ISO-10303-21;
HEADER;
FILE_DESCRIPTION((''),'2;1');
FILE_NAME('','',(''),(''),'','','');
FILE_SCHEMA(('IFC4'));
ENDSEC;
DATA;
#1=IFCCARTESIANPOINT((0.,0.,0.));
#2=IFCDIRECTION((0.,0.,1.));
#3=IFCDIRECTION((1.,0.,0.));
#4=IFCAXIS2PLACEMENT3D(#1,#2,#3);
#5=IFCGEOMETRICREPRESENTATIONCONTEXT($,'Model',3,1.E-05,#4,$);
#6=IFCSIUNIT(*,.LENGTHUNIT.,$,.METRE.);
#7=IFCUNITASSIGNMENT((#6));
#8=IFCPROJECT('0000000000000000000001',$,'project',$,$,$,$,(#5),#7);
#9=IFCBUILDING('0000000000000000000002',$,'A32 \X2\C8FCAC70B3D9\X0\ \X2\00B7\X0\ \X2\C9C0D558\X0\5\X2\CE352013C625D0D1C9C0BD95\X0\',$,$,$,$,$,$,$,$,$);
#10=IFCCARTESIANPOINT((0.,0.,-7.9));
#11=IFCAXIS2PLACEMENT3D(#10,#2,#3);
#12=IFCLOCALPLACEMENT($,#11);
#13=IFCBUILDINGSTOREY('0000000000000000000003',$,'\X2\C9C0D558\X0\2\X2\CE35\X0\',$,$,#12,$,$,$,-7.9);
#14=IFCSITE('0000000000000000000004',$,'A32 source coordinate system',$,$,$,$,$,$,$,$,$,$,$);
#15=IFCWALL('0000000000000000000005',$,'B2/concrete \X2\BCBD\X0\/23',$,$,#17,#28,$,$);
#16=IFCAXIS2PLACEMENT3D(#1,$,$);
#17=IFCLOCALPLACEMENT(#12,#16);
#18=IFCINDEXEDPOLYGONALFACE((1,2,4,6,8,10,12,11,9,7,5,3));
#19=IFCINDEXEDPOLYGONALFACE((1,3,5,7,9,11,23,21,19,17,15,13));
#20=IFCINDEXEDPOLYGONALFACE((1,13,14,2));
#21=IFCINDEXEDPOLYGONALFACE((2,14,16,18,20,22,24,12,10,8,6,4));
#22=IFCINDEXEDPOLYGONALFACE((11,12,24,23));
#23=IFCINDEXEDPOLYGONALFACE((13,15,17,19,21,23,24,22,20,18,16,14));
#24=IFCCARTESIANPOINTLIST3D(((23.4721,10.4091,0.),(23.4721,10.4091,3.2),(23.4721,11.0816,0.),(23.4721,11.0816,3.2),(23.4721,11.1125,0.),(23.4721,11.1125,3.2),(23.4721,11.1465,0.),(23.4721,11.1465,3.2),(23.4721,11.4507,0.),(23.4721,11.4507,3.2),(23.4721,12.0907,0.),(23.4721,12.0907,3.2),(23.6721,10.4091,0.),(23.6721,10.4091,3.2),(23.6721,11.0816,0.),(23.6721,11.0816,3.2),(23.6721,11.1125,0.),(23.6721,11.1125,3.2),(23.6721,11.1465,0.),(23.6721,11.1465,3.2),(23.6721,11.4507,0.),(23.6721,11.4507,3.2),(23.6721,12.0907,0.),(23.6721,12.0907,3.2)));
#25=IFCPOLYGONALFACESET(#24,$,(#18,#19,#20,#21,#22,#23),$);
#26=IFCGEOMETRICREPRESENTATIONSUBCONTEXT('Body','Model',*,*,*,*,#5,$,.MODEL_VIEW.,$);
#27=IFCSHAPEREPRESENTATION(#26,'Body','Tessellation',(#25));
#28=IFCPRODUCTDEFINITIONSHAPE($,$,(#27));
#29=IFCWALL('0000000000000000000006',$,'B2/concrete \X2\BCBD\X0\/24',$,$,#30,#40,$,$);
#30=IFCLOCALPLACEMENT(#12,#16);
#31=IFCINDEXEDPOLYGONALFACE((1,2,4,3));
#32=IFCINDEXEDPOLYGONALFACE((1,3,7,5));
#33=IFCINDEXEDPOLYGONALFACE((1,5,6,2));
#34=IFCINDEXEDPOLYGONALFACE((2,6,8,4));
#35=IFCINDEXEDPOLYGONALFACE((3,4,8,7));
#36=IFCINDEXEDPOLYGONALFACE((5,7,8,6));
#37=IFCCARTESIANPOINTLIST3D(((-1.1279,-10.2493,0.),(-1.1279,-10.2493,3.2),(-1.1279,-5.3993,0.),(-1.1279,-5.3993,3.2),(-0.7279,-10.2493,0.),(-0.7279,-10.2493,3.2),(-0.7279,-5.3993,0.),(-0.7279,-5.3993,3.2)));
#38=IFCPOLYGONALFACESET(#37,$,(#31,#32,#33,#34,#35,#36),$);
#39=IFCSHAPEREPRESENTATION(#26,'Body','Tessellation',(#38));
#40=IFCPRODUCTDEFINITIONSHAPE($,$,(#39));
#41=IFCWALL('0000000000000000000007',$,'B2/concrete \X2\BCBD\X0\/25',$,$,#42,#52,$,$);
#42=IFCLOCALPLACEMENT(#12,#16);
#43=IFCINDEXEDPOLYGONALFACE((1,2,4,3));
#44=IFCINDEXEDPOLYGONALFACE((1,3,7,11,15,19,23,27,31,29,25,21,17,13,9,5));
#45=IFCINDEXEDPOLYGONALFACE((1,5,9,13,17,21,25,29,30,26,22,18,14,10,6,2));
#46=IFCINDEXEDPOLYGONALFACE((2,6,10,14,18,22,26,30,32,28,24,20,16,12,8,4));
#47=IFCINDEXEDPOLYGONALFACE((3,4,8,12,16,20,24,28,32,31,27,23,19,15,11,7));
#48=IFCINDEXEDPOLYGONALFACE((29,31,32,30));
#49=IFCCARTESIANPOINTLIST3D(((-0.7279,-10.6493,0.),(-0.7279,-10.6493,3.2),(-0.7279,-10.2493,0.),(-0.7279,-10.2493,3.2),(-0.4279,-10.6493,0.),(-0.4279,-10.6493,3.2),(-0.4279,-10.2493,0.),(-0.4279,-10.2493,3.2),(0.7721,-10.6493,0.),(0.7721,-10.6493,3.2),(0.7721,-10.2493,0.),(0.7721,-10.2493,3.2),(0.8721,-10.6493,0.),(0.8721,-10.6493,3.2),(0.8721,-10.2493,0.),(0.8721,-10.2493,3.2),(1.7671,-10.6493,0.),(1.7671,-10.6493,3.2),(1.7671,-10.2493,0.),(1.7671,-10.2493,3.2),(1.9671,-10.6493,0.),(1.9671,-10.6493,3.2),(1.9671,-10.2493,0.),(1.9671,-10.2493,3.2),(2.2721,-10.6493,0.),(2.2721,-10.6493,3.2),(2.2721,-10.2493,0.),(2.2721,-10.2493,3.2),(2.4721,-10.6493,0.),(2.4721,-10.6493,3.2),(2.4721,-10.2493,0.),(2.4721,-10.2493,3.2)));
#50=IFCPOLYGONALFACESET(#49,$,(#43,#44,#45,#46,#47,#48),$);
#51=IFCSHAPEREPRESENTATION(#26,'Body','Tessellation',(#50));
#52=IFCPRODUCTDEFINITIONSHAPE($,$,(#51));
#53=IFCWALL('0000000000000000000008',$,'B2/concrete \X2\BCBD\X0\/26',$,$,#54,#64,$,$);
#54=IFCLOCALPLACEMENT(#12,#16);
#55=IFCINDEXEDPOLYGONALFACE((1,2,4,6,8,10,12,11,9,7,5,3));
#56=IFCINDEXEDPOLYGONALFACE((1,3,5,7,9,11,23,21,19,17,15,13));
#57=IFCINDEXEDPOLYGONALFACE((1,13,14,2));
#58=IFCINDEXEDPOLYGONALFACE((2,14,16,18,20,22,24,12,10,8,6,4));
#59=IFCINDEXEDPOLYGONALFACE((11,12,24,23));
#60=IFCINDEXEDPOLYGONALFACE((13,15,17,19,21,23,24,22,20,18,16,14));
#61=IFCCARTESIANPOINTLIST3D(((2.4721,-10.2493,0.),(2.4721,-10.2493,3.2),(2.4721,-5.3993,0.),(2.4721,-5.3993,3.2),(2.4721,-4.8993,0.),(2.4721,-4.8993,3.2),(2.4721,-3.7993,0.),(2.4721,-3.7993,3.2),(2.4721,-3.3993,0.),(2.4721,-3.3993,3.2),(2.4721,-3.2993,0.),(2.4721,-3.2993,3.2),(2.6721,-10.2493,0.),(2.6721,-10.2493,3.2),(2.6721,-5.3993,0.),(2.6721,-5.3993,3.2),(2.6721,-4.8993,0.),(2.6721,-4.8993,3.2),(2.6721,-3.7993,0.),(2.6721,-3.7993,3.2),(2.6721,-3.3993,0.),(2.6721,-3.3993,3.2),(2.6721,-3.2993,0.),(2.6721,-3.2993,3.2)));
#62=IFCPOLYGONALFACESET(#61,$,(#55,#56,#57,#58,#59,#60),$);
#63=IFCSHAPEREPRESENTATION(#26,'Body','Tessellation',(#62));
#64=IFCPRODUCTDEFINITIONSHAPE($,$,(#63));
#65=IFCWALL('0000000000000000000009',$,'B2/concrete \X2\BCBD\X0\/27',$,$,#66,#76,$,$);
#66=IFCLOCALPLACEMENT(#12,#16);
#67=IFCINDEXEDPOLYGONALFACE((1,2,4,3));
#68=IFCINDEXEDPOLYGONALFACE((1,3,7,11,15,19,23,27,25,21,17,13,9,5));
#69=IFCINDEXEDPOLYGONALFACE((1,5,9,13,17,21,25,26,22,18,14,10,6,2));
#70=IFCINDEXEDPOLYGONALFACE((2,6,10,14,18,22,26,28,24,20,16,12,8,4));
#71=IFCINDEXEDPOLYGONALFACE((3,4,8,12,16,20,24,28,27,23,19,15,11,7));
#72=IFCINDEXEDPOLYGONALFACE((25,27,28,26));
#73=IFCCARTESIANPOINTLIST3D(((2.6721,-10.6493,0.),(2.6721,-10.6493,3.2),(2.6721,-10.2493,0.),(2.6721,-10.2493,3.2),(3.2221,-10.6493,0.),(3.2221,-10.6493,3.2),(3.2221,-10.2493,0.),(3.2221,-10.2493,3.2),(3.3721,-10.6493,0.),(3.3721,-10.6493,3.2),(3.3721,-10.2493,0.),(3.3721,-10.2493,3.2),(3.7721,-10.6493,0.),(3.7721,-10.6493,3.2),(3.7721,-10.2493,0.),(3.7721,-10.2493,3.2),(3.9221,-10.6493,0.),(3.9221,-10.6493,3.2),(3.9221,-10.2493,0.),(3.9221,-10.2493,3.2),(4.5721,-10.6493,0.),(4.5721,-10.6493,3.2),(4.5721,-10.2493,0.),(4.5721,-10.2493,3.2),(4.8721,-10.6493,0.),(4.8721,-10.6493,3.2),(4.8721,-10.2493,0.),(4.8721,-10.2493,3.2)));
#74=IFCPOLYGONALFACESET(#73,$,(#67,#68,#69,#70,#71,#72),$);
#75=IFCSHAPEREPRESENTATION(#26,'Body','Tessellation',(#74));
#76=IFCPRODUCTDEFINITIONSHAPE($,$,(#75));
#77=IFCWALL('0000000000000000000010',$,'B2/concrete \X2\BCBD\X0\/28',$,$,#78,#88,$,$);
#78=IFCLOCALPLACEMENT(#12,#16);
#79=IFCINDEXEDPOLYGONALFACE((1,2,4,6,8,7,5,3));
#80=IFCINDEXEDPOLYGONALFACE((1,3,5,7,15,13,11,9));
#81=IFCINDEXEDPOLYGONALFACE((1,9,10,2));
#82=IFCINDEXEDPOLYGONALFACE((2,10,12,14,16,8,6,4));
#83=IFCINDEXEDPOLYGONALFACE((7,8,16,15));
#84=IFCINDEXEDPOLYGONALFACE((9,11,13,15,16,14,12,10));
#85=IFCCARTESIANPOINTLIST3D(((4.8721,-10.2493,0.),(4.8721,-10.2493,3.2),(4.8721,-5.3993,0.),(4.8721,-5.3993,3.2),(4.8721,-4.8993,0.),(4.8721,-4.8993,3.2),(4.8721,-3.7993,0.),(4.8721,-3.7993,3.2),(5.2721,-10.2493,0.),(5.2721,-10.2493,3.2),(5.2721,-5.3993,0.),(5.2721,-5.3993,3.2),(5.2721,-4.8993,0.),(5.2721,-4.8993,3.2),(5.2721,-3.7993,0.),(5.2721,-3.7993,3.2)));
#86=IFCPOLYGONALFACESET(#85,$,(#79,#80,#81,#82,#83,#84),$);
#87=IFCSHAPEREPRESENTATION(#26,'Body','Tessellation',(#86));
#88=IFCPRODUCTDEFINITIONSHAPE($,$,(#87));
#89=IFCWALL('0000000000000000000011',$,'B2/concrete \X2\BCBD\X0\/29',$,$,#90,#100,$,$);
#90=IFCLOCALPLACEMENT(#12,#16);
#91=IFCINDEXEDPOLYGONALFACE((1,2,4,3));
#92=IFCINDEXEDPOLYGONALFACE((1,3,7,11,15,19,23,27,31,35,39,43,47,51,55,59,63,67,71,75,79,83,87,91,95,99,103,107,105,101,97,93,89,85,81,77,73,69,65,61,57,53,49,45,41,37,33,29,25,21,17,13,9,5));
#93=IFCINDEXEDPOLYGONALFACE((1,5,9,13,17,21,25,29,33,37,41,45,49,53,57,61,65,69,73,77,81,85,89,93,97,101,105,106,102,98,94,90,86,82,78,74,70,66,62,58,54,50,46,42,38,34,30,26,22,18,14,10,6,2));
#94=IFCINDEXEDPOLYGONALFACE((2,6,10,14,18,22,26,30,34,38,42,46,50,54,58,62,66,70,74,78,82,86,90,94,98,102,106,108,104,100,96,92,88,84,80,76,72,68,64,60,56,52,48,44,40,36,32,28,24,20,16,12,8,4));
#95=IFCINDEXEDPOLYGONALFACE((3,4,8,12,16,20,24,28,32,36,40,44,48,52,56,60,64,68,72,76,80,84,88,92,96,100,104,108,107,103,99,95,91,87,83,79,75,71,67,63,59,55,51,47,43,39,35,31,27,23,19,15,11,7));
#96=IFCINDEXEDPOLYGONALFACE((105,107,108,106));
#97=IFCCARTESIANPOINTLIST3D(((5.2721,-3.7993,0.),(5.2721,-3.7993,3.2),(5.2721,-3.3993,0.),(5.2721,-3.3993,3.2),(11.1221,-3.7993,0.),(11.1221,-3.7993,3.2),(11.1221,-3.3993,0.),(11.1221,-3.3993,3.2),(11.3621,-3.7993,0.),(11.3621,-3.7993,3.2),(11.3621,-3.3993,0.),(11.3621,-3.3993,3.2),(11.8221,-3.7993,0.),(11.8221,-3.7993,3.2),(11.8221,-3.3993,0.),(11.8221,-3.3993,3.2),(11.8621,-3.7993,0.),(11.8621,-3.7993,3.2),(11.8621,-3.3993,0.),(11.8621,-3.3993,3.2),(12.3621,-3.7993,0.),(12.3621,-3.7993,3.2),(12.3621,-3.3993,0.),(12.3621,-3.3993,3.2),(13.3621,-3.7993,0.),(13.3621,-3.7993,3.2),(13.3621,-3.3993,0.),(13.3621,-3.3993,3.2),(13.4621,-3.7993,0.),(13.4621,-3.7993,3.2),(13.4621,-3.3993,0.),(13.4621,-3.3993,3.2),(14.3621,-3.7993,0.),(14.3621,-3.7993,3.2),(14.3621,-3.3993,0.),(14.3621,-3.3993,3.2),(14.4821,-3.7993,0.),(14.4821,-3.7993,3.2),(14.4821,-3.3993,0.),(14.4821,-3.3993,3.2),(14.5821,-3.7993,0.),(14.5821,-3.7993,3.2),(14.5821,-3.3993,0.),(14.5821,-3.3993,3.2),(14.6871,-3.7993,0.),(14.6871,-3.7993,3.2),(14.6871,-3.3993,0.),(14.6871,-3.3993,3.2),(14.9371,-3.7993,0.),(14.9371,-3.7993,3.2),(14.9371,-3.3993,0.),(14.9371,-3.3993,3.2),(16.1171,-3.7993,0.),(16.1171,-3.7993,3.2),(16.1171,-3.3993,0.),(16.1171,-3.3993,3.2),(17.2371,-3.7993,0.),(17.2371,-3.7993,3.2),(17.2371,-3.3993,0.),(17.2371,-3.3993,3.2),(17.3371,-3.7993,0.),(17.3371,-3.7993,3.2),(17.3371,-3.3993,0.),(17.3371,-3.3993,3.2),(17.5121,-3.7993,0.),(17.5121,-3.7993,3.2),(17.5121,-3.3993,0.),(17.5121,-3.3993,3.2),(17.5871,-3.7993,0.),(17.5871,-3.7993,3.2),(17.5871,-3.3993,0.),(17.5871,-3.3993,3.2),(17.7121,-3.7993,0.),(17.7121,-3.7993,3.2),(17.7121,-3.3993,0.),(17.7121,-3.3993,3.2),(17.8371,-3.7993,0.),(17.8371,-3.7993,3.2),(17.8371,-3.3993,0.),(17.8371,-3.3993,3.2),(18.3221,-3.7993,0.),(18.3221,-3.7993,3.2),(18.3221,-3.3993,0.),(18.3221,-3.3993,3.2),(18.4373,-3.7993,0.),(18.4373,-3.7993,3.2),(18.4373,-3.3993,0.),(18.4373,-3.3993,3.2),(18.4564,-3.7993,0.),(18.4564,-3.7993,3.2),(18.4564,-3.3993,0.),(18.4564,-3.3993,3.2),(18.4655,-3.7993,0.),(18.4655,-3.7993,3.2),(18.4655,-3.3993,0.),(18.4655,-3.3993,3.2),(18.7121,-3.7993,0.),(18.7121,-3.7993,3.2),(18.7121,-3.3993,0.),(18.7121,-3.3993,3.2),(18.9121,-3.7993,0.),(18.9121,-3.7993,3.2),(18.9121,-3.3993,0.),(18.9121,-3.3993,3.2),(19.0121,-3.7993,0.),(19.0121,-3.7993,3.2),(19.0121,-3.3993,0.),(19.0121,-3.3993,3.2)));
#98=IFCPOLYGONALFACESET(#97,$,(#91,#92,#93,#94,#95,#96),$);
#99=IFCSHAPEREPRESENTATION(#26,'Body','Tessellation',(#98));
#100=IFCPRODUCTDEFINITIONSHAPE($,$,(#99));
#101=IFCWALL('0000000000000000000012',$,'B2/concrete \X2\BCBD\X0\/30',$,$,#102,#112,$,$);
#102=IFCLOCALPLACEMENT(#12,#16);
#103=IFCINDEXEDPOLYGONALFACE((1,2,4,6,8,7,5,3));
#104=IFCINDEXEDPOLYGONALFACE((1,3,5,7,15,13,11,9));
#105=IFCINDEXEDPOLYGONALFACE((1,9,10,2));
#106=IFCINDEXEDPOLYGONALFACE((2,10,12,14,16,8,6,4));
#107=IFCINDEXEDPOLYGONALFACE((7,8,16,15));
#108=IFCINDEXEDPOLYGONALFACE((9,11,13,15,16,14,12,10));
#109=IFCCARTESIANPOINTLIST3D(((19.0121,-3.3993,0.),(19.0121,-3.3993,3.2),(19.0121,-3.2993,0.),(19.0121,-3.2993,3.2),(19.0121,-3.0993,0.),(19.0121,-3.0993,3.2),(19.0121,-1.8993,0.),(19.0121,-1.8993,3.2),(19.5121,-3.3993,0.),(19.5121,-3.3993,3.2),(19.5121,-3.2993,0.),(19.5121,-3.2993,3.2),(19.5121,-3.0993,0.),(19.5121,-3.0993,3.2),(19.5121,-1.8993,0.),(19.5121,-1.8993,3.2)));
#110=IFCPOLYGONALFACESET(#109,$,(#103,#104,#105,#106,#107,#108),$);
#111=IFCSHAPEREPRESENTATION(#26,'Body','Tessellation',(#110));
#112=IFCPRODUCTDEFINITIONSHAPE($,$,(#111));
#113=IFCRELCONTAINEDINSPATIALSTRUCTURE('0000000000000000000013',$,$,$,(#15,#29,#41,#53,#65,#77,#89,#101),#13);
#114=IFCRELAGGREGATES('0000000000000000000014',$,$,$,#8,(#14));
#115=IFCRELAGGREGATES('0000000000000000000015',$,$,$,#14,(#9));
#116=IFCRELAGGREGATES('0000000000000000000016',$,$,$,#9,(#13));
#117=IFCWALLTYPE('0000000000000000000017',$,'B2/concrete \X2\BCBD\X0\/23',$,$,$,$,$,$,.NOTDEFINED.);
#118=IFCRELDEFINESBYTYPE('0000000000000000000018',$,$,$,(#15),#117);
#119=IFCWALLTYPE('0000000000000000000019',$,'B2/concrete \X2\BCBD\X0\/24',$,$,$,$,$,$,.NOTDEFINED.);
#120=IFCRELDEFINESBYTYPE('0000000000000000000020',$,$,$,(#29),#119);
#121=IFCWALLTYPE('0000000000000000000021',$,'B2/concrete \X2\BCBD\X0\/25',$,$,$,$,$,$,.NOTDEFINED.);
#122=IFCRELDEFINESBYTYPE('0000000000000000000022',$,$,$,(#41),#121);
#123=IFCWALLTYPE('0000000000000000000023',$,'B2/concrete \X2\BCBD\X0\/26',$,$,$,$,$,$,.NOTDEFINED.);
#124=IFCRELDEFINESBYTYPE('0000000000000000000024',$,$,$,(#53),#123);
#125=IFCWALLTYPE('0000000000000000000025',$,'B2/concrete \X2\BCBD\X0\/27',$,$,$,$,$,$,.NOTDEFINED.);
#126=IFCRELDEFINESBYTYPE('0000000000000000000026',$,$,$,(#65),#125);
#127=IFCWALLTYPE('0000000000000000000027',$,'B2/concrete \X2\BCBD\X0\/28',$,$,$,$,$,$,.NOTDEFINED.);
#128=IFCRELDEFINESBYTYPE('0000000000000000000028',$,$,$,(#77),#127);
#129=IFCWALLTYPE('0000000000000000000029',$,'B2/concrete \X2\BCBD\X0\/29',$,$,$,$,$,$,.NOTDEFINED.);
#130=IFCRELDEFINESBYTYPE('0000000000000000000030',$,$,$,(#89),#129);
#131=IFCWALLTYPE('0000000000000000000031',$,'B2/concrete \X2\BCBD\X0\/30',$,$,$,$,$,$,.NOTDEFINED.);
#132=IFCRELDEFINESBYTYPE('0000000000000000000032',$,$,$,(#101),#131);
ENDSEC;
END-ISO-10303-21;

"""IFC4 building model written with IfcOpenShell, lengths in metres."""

from ifc_helpers import new_model, si_unit, frame, origin, origin_with_axes, place, context, subcontext, project, spatial, polyline, outline, extrude, source, transform, mapped, type_object, type_shapes, element, save


model = new_model("IFC4")

# Units and contexts
model_context = context("Model", 3, precision=1e-05, world=origin_with_axes())
body_context = subcontext(model_context, "Body", "Model", "MODEL_VIEW")
ifc_project = project(units=[si_unit("LENGTHUNIT", "METRE")], contexts=[model_context])

# Site, building, storey
site = spatial("IfcSite", under=ifc_project, Name="A32 source coordinate system")
building = spatial("IfcBuilding", under=site, Name="A32 주거동 · 지하5층–옥탑지붕")
storey_placement = place(None, frame((0.0, 0.0, -7.9), z_axis=(0.0, 0.0, 1.0), x_axis=(1.0, 0.0, 0.0)))
storey = spatial("IfcBuildingStorey", under=building, at=storey_placement, Name="지하2층", Elevation=-7.9)

# Walls
wall_type_1 = type_object("IfcWallType", Name="B2/concrete 벽/23", PredefinedType="NOTDEFINED")
shared_shape_1 = source(origin(), body_context, "Body", "SweptSolid", [
    extrude(outline(polyline([(23.4721, 11.1125), (23.4721, 11.1465), (23.4721, 11.4507), (23.4721, 12.0907), (23.6721, 12.0907), (23.6721, 11.4507), (23.6721, 11.1465), (23.6721, 11.1125), (23.6721, 11.0816), (23.6721, 10.4091), (23.4721, 10.4091), (23.4721, 11.0816), (23.4721, 11.1125)])), origin(), (0.0, 0.0, 1.0), 3.2),
])
type_shapes(wall_type_1, [shared_shape_1])
wall_1_placement = place(storey_placement, origin_with_axes())
element("IfcWall", 1, at=wall_1_placement, inside=storey, type_object=wall_type_1, Name="B2/concrete 벽/23", context=body_context, shape_type="MappedRepresentation", body=[
    mapped(shared_shape_1, transform((0.0, 0.0, 0.0), scale=1.0)),
])
wall_type_2 = type_object("IfcWallType", Name="B2/concrete 벽/24", PredefinedType="NOTDEFINED")
shared_shape_2 = source(origin(), body_context, "Body", "SweptSolid", [
    extrude(outline(polyline([(-1.1279, -10.2493), (-1.1279, -5.3993), (-0.7279, -5.3993), (-0.7279, -10.2493), (-1.1279, -10.2493)])), origin(), (0.0, 0.0, 1.0), 3.2),
])
type_shapes(wall_type_2, [shared_shape_2])
wall_2_placement = place(storey_placement, origin_with_axes())
element("IfcWall", 2, at=wall_2_placement, inside=storey, type_object=wall_type_2, Name="B2/concrete 벽/24", context=body_context, shape_type="MappedRepresentation", body=[
    mapped(shared_shape_2, transform((0.0, 0.0, 0.0), scale=1.0)),
])
wall_type_3 = type_object("IfcWallType", Name="B2/concrete 벽/25", PredefinedType="NOTDEFINED")
shared_shape_3 = source(origin(), body_context, "Body", "SweptSolid", [
    extrude(outline(polyline([(0.8721, -10.2493), (1.7671, -10.2493), (1.9671, -10.2493), (2.2721, -10.2493), (2.4721, -10.2493), (2.4721, -10.6493), (2.2721, -10.6493), (1.9671, -10.6493), (1.7671, -10.6493), (0.8721, -10.6493), (0.7721, -10.6493), (-0.4279, -10.6493), (-0.7279, -10.6493), (-0.7279, -10.2493), (-0.4279, -10.2493), (0.7721, -10.2493), (0.8721, -10.2493)])), origin(), (0.0, 0.0, 1.0), 3.2),
])
type_shapes(wall_type_3, [shared_shape_3])
wall_3_placement = place(storey_placement, origin_with_axes())
element("IfcWall", 3, at=wall_3_placement, inside=storey, type_object=wall_type_3, Name="B2/concrete 벽/25", context=body_context, shape_type="MappedRepresentation", body=[
    mapped(shared_shape_3, transform((0.0, 0.0, 0.0), scale=1.0)),
])
wall_type_4 = type_object("IfcWallType", Name="B2/concrete 벽/26", PredefinedType="NOTDEFINED")
shared_shape_4 = source(origin(), body_context, "Body", "SweptSolid", [
    extrude(outline(polyline([(2.4721, -3.7993), (2.4721, -3.3993), (2.4721, -3.2993), (2.6721, -3.2993), (2.6721, -3.3993), (2.6721, -3.7993), (2.6721, -4.8993), (2.6721, -5.3993), (2.6721, -10.2493), (2.4721, -10.2493), (2.4721, -5.3993), (2.4721, -4.8993), (2.4721, -3.7993)])), origin(), (0.0, 0.0, 1.0), 3.2),
])
type_shapes(wall_type_4, [shared_shape_4])
wall_4_placement = place(storey_placement, origin_with_axes())
element("IfcWall", 4, at=wall_4_placement, inside=storey, type_object=wall_type_4, Name="B2/concrete 벽/26", context=body_context, shape_type="MappedRepresentation", body=[
    mapped(shared_shape_4, transform((0.0, 0.0, 0.0), scale=1.0)),
])
wall_type_5 = type_object("IfcWallType", Name="B2/concrete 벽/27", PredefinedType="NOTDEFINED")
shared_shape_5 = source(origin(), body_context, "Body", "SweptSolid", [
    extrude(outline(polyline([(3.7721, -10.2493), (3.9221, -10.2493), (4.5721, -10.2493), (4.8721, -10.2493), (4.8721, -10.6493), (4.5721, -10.6493), (3.9221, -10.6493), (3.7721, -10.6493), (3.3721, -10.6493), (3.2221, -10.6493), (2.6721, -10.6493), (2.6721, -10.2493), (3.2221, -10.2493), (3.3721, -10.2493), (3.7721, -10.2493)])), origin(), (0.0, 0.0, 1.0), 3.2),
])
type_shapes(wall_type_5, [shared_shape_5])
wall_5_placement = place(storey_placement, origin_with_axes())
element("IfcWall", 5, at=wall_5_placement, inside=storey, type_object=wall_type_5, Name="B2/concrete 벽/27", context=body_context, shape_type="MappedRepresentation", body=[
    mapped(shared_shape_5, transform((0.0, 0.0, 0.0), scale=1.0)),
])
wall_type_6 = type_object("IfcWallType", Name="B2/concrete 벽/28", PredefinedType="NOTDEFINED")
shared_shape_6 = source(origin(), body_context, "Body", "SweptSolid", [
    extrude(outline(polyline([(4.8721, -3.7993), (5.2721, -3.7993), (5.2721, -4.8993), (5.2721, -5.3993), (5.2721, -10.2493), (4.8721, -10.2493), (4.8721, -5.3993), (4.8721, -4.8993), (4.8721, -3.7993)])), origin(), (0.0, 0.0, 1.0), 3.2),
])
type_shapes(wall_type_6, [shared_shape_6])
wall_6_placement = place(storey_placement, origin_with_axes())
element("IfcWall", 6, at=wall_6_placement, inside=storey, type_object=wall_type_6, Name="B2/concrete 벽/28", context=body_context, shape_type="MappedRepresentation", body=[
    mapped(shared_shape_6, transform((0.0, 0.0, 0.0), scale=1.0)),
])
wall_type_7 = type_object("IfcWallType", Name="B2/concrete 벽/29", PredefinedType="NOTDEFINED")
shared_shape_7 = source(origin(), body_context, "Body", "SweptSolid", [
    extrude(outline(polyline([(11.3621, -3.3993), (11.8221, -3.3993), (11.8621, -3.3993), (12.3621, -3.3993), (13.3621, -3.3993), (13.4621, -3.3993), (14.3621, -3.3993), (14.4821, -3.3993), (14.5821, -3.3993), (14.6871, -3.3993), (14.9371, -3.3993), (16.1171, -3.3993), (17.2371, -3.3993), (17.3371, -3.3993), (17.5121, -3.3993), (17.5871, -3.3993), (17.7121, -3.3993), (17.8371, -3.3993), (18.3221, -3.3993), (18.4373, -3.3993), (18.4564, -3.3993), (18.4655, -3.3993), (18.7121, -3.3993), (18.9121, -3.3993), (19.0121, -3.3993), (19.0121, -3.7993), (18.9121, -3.7993), (18.7121, -3.7993), (18.4655, -3.7993), (18.4564, -3.7993), (18.4373, -3.7993), (18.3221, -3.7993), (17.8371, -3.7993), (17.7121, -3.7993), (17.5871, -3.7993), (17.5121, -3.7993), (17.3371, -3.7993), (17.2371, -3.7993), (16.1171, -3.7993), (14.9371, -3.7993), (14.6871, -3.7993), (14.5821, -3.7993), (14.4821, -3.7993), (14.3621, -3.7993), (13.4621, -3.7993), (13.3621, -3.7993), (12.3621, -3.7993), (11.8621, -3.7993), (11.8221, -3.7993), (11.3621, -3.7993), (11.1221, -3.7993), (5.2721, -3.7993), (5.2721, -3.3993), (11.1221, -3.3993), (11.3621, -3.3993)])), origin(), (0.0, 0.0, 1.0), 3.2),
])
type_shapes(wall_type_7, [shared_shape_7])
wall_7_placement = place(storey_placement, origin_with_axes())
element("IfcWall", 7, at=wall_7_placement, inside=storey, type_object=wall_type_7, Name="B2/concrete 벽/29", context=body_context, shape_type="MappedRepresentation", body=[
    mapped(shared_shape_7, transform((0.0, 0.0, 0.0), scale=1.0)),
])
wall_type_8 = type_object("IfcWallType", Name="B2/concrete 벽/30", PredefinedType="NOTDEFINED")
shared_shape_8 = source(origin(), body_context, "Body", "SweptSolid", [
    extrude(outline(polyline([(19.0121, -1.8993), (19.5121, -1.8993), (19.5121, -3.0993), (19.5121, -3.2993), (19.5121, -3.3993), (19.0121, -3.3993), (19.0121, -3.2993), (19.0121, -3.0993), (19.0121, -1.8993)])), origin(), (0.0, 0.0, 1.0), 3.2),
])
type_shapes(wall_type_8, [shared_shape_8])
wall_8_placement = place(storey_placement, origin_with_axes())
element("IfcWall", 8, at=wall_8_placement, inside=storey, type_object=wall_type_8, Name="B2/concrete 벽/30", context=body_context, shape_type="MappedRepresentation", body=[
    mapped(shared_shape_8, transform((0.0, 0.0, 0.0), scale=1.0)),
])

save(model, "model.ifc")
